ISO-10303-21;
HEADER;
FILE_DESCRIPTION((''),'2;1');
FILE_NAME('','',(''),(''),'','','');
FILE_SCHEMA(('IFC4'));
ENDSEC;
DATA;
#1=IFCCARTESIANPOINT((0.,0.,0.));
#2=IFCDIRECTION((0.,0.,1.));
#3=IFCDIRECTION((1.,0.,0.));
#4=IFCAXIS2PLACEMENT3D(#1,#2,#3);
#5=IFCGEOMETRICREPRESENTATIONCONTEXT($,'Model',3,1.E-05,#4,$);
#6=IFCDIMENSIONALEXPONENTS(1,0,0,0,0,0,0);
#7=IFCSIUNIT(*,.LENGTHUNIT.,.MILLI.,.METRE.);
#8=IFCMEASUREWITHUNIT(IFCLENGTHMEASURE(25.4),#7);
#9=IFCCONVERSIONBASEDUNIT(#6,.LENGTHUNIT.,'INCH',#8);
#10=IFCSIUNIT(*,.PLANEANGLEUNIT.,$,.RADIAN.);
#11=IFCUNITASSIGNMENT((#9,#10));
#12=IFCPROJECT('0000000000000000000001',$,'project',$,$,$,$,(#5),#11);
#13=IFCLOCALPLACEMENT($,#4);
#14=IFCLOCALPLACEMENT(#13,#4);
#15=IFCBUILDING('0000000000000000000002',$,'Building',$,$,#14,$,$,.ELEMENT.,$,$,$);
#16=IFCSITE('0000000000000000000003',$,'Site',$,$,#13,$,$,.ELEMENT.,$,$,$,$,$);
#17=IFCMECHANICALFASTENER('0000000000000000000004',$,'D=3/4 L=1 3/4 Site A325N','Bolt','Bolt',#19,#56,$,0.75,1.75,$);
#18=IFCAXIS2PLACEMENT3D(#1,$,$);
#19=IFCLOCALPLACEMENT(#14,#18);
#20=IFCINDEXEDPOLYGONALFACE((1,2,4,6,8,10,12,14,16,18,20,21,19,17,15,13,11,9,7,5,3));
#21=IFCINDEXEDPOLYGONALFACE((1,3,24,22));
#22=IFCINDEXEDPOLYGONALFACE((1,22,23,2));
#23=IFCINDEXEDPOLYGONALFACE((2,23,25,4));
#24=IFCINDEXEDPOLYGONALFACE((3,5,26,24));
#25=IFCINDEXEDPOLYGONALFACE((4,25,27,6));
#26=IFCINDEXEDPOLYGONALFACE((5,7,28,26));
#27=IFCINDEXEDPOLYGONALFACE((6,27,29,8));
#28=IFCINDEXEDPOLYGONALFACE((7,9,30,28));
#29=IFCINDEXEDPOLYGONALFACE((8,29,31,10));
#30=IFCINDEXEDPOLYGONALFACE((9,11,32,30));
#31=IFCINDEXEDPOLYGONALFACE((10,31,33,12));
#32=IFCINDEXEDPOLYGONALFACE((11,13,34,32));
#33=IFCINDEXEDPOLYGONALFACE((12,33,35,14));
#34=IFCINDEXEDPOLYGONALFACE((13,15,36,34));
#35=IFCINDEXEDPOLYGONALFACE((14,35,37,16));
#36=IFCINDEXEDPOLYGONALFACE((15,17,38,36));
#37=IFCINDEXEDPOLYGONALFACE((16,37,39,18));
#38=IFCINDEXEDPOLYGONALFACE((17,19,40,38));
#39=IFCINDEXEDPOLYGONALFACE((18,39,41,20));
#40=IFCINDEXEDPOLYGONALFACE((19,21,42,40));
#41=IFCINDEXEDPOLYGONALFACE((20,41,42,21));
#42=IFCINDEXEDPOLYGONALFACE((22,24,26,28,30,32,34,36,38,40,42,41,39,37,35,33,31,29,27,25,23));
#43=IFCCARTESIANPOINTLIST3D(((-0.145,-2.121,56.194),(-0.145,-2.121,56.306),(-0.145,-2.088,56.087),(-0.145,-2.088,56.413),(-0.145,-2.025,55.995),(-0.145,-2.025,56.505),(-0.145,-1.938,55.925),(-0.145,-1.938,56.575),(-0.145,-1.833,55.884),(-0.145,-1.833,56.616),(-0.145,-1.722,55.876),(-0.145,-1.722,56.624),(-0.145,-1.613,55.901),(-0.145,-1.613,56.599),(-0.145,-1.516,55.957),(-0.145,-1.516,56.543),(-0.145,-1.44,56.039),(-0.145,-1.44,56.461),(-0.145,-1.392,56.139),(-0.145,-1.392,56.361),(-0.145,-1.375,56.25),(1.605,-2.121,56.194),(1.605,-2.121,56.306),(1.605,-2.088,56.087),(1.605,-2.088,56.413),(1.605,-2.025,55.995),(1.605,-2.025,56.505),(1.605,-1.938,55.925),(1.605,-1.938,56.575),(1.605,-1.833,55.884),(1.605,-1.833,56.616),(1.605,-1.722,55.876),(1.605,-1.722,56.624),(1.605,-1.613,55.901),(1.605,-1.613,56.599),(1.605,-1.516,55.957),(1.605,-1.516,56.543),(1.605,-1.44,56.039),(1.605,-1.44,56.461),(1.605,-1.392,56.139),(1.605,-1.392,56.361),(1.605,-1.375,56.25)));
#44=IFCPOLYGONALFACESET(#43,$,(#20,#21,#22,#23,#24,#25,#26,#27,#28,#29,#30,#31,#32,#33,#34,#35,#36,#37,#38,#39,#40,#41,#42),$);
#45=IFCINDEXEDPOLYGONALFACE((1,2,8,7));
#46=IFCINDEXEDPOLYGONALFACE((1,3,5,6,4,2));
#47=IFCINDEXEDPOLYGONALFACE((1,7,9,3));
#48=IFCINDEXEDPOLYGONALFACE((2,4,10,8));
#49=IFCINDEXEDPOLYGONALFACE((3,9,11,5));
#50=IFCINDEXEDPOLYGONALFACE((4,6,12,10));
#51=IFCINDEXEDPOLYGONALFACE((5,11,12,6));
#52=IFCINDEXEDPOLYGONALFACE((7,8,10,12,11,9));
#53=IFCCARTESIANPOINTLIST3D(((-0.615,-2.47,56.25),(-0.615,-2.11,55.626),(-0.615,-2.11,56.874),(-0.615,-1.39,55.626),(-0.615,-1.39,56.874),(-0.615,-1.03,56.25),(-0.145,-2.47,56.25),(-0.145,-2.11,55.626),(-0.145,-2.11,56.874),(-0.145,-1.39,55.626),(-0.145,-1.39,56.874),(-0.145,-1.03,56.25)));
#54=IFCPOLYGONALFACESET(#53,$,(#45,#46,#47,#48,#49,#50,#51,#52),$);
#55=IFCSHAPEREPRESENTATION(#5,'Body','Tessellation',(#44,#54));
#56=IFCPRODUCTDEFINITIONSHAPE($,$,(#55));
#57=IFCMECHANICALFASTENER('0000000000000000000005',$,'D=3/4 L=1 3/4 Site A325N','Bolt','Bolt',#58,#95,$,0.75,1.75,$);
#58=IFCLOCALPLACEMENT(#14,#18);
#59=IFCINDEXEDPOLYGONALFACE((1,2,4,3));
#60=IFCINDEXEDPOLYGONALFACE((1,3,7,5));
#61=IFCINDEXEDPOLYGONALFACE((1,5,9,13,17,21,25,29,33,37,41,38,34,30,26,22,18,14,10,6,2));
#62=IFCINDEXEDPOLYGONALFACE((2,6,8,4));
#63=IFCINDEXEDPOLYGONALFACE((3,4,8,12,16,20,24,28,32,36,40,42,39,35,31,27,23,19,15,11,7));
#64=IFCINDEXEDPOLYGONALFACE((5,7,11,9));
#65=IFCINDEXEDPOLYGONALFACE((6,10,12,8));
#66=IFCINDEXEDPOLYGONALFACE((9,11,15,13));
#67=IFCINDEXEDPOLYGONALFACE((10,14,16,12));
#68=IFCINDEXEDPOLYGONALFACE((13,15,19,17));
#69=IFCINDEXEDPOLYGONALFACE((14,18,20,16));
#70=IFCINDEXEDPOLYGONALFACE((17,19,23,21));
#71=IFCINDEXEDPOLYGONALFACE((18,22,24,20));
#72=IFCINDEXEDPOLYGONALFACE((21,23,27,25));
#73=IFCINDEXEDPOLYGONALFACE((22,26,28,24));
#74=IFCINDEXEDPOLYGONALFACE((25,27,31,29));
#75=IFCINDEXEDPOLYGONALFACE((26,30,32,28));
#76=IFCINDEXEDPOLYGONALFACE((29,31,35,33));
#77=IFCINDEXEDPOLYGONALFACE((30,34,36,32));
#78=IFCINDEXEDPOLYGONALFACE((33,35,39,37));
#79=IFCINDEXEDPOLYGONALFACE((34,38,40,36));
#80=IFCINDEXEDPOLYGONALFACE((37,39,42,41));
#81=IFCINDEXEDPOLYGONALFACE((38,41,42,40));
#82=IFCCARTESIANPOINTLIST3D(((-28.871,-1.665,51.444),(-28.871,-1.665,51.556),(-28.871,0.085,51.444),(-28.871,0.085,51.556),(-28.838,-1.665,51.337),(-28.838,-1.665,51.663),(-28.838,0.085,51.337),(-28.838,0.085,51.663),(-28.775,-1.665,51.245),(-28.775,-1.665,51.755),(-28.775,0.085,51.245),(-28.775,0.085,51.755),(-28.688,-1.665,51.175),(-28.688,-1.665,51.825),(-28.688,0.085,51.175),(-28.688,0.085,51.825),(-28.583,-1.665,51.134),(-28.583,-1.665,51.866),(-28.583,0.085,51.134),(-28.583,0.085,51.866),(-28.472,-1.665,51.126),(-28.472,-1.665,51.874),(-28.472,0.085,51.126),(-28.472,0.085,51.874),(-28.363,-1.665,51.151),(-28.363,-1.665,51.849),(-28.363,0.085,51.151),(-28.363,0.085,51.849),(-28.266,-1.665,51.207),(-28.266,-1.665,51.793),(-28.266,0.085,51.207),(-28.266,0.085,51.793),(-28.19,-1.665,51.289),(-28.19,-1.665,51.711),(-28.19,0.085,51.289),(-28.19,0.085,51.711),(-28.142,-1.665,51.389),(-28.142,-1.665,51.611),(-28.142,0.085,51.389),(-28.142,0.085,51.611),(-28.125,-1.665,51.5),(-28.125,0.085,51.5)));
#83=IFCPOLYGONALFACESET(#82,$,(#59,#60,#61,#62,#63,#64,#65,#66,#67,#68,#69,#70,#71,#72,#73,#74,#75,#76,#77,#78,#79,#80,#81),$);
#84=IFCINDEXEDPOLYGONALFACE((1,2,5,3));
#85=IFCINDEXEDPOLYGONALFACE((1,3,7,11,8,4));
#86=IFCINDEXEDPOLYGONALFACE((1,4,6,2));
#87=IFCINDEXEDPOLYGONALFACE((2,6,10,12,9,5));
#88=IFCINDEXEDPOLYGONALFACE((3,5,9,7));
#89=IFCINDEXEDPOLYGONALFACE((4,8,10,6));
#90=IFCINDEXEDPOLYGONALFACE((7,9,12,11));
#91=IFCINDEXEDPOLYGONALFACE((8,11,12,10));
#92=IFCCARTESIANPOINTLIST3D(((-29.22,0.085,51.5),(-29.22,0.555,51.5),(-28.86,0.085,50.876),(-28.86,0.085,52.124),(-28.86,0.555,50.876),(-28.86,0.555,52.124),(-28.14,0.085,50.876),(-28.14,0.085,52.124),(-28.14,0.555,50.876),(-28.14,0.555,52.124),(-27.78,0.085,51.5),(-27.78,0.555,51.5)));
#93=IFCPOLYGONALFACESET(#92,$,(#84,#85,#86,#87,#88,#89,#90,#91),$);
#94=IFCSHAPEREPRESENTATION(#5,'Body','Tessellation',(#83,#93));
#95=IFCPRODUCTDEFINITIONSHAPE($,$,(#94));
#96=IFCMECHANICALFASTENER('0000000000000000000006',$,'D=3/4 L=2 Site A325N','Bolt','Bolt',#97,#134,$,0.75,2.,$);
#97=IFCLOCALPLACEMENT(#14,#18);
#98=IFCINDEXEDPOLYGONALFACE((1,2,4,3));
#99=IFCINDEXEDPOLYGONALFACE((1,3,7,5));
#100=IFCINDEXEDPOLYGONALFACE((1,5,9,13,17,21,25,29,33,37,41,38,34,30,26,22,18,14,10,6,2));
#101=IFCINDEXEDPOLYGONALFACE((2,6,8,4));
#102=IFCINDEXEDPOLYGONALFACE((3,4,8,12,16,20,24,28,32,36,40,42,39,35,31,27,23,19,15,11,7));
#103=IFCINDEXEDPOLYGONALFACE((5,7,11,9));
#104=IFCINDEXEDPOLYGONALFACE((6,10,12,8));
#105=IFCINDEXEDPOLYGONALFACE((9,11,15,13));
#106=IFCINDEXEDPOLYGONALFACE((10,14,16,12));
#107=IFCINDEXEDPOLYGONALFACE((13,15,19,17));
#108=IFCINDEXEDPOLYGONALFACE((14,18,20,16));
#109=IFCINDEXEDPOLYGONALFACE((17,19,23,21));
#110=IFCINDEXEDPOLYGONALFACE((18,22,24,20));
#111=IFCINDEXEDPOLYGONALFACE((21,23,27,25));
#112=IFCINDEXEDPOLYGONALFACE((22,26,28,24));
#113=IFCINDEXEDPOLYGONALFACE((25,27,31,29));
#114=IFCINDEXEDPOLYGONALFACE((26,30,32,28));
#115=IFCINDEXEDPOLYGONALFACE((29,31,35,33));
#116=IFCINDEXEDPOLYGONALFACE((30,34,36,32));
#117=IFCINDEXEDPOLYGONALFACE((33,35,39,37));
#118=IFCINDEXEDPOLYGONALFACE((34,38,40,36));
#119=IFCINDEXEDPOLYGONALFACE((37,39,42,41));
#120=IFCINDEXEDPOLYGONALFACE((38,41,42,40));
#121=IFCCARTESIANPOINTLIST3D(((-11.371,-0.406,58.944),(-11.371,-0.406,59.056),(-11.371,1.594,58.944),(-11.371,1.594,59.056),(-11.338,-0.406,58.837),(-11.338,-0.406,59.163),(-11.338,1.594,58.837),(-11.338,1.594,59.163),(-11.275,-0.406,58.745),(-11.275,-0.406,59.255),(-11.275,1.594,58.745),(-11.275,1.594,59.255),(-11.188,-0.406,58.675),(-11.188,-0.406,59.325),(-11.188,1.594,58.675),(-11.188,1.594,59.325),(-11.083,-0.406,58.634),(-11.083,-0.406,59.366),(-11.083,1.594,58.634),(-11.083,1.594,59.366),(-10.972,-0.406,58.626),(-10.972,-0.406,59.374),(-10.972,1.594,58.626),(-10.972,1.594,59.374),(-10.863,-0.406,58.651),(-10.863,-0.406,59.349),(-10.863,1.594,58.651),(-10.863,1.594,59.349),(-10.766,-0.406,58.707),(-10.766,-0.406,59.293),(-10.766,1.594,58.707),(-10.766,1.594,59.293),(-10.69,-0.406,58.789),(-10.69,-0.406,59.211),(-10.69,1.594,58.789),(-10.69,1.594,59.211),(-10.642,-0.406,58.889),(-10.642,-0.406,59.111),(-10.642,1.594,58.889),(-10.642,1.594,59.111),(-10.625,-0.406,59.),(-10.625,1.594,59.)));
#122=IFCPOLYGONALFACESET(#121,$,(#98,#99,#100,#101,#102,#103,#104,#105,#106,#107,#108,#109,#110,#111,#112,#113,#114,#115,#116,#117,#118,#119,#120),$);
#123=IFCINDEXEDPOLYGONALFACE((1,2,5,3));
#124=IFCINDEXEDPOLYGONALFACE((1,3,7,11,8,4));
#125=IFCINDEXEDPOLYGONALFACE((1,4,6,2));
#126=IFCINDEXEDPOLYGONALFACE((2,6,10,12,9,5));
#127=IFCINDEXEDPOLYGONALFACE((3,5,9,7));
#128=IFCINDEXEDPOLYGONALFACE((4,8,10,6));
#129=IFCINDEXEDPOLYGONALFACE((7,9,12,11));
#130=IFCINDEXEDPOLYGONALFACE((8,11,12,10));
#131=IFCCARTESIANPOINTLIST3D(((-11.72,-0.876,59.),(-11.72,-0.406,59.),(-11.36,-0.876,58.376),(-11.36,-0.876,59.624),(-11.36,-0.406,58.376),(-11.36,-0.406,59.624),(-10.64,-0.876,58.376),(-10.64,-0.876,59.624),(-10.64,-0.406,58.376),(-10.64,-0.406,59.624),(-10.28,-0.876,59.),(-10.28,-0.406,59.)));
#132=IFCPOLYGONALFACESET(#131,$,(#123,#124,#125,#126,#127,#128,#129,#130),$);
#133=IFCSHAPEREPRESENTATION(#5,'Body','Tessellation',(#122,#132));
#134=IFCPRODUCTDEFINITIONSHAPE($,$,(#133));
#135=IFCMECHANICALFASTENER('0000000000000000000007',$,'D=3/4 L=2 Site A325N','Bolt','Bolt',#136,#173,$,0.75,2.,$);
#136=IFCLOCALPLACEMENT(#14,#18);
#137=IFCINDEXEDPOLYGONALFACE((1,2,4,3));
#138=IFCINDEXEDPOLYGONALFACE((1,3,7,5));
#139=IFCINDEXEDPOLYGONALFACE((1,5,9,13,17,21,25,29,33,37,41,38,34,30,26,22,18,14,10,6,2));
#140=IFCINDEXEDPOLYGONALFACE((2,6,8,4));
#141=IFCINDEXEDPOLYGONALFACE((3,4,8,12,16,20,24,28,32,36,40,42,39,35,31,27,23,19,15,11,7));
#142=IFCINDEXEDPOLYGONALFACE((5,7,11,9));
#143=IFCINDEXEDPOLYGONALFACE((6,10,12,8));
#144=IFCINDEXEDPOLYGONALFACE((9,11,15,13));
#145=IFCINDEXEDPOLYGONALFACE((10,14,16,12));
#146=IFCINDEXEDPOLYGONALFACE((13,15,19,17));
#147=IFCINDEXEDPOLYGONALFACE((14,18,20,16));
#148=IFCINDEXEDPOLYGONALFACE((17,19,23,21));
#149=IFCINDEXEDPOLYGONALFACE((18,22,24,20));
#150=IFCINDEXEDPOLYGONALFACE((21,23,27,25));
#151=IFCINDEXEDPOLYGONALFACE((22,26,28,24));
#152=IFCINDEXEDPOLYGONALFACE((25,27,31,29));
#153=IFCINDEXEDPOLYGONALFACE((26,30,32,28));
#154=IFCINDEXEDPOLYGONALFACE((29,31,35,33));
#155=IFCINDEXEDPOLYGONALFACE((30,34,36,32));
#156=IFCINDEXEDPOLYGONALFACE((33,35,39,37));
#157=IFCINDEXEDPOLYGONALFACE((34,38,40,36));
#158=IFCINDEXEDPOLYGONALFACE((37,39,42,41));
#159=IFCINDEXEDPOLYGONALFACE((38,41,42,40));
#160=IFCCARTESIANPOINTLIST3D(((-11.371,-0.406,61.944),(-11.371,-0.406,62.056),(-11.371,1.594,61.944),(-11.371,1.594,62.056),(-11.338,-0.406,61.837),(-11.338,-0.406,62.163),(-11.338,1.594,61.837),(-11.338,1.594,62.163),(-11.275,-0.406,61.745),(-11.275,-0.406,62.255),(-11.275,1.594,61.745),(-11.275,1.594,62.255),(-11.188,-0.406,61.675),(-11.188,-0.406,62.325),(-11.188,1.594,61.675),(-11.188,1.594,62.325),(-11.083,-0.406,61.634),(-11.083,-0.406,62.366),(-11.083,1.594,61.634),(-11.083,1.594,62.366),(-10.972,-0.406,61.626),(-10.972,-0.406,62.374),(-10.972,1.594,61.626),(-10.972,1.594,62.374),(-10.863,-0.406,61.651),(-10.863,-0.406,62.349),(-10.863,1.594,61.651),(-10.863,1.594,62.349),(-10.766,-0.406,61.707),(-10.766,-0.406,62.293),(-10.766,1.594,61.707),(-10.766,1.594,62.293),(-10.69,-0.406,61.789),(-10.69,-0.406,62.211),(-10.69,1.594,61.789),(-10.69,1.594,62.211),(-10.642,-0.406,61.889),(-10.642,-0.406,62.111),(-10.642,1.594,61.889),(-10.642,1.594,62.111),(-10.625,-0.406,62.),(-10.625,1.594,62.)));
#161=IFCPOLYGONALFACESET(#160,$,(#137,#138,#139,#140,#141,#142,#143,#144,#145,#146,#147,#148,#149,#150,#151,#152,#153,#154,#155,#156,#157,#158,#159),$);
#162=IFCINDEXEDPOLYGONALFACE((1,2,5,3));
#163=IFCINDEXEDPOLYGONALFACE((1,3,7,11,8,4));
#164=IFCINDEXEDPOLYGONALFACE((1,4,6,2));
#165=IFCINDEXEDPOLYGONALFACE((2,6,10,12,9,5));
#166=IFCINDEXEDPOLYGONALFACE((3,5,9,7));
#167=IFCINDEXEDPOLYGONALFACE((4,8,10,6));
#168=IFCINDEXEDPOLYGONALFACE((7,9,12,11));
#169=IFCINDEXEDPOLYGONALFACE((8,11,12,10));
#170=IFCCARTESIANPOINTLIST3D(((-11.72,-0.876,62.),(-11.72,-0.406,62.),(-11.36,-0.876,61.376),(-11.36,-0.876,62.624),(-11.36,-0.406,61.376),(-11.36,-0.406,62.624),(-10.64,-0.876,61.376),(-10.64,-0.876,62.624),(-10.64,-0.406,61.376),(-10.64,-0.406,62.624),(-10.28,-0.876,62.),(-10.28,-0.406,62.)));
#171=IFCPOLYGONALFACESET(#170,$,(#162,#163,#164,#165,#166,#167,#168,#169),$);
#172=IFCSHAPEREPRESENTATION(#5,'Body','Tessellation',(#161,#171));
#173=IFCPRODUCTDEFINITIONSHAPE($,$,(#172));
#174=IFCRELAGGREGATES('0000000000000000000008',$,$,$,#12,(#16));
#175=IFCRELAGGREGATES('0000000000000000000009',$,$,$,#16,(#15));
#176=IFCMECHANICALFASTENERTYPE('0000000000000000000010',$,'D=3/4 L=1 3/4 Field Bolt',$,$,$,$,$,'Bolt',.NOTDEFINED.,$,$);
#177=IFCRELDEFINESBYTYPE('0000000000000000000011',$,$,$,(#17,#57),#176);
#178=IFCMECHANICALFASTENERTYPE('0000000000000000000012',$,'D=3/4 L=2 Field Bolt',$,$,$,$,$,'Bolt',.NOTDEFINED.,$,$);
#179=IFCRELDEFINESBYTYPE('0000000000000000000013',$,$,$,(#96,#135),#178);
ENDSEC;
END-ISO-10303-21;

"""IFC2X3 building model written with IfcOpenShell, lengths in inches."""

from ifc_helpers import new_model, entity, si_unit, converted_unit, frame, origin_with_axes, origin_2d_with_axis, place, context, project, spatial, polyline, circle, outline, extrude, source, transform, mapped, type_object, type_shapes, element, save


model = new_model("IFC2X3")

# Units and contexts
model_context = context("Model", 3, precision=1e-05, world=origin_with_axes())
ifc_project = project(units=[converted_unit("LENGTHUNIT", "INCH", entity("IfcLengthMeasure", 25.4), si_unit("LENGTHUNIT", "METRE", prefix="MILLI"), dimensions=[1, 0, 0, 0, 0, 0, 0]), si_unit("PLANEANGLEUNIT", "RADIAN")], contexts=[model_context])

# Site, building
site_placement = place(None, origin_with_axes())
site = spatial("IfcSite", under=ifc_project, at=site_placement, Name="Site", CompositionType="ELEMENT")
building_placement = place(site_placement, origin_with_axes())
building = spatial("IfcBuilding", under=site, at=building_placement, Name="Building", CompositionType="ELEMENT")

# Shared definitions
assembly_1_placement = place(building_placement, frame((-9.25, 0.0, 50.0), z_axis=(-1.0, 0.0, 0.0), x_axis=(0.0, 0.0, 1.0)))

# Shared definitions
assembly_2_placement = place(building_placement, frame((-9.25, 0.0, 57.0), z_axis=(0.0, 0.0, 1.0), x_axis=(-1.0, 0.0, 0.0)))

# Mechanical fasteners
mechanical_fastener_type_1 = type_object("IfcMechanicalFastenerType", Name="D=3/4 L=1 3/4 Field Bolt", ElementType="Bolt")
shared_shape_1 = source(origin_with_axes(), model_context, "Body", "SweptSolid", [
    extrude(circle(Radius=0.375, at=origin_2d_with_axis()), frame((0.0, 0.0, 0.0), z_axis=(1.0, 0.0, 0.0), x_axis=(0.0, 1.0, 0.0)), (0.0, 0.0, 1.0), 1.75),
    extrude(outline(polyline([(-0.72, 0.0), (-0.36, 0.624), (0.36, 0.624), (0.72, 0.0), (0.36, -0.624), (-0.36, -0.624), (-0.72, 0.0)])), frame((0.0, 0.0, 0.0), z_axis=(1.0, 0.0, 0.0), x_axis=(0.0, 1.0, 0.0)), (0.0, 0.0, -1.0), 0.47),
])
type_shapes(mechanical_fastener_type_1, [shared_shape_1])
placement_1 = place(building_placement, frame((0.0, 0.0, 54.5), z_axis=(0.0, -1.0, 0.0), x_axis=(0.0, 0.0, 1.0)))
placement_2 = place(placement_1, frame((1.75, 0.145, 1.75), z_axis=(1.0, 0.0, 0.0), x_axis=(0.0, -1.0, 0.0)))
mechanical_fastener_1_placement = place(placement_2, origin_with_axes())
element("IfcMechanicalFastener", 1, at=mechanical_fastener_1_placement, type_object=mechanical_fastener_type_1, Name="D=3/4 L=1 3/4 Site A325N", Description="Bolt", ObjectType="Bolt", NominalDiameter=0.75, NominalLength=1.75, context=model_context, shape_type="MappedRepresentation", body=[
    mapped(shared_shape_1, transform((0.0, 0.0, 0.0), scale=1.0)),
])
placement_3 = place(assembly_2_placement, frame((19.25, -0.085, -2.5), z_axis=(0.0, 0.0, 1.0), x_axis=(0.0, 1.0, 0.0)))
mechanical_fastener_2_placement = place(placement_3, frame((0.0, 0.0, -3.0), z_axis=(0.0, 0.0, 1.0), x_axis=(1.0, 0.0, 0.0)))
element("IfcMechanicalFastener", 2, at=mechanical_fastener_2_placement, type_object=mechanical_fastener_type_1, Name="D=3/4 L=1 3/4 Site A325N", Description="Bolt", ObjectType="Bolt", NominalDiameter=0.75, NominalLength=1.75, context=model_context, shape_type="MappedRepresentation", body=[
    mapped(shared_shape_1, transform((0.0, 0.0, 0.0), scale=1.0)),
])
mechanical_fastener_type_2 = type_object("IfcMechanicalFastenerType", Name="D=3/4 L=2 Field Bolt", ElementType="Bolt")
shared_shape_2 = source(origin_with_axes(), model_context, "Body", "SweptSolid", [
    extrude(circle(Radius=0.375, at=origin_2d_with_axis()), frame((0.0, 0.0, 0.0), z_axis=(1.0, 0.0, 0.0), x_axis=(0.0, 1.0, 0.0)), (0.0, 0.0, 1.0), 2.0),
    extrude(outline(polyline([(-0.72, 0.0), (-0.36, 0.624), (0.36, 0.624), (0.72, 0.0), (0.36, -0.624), (-0.36, -0.624), (-0.72, 0.0)])), frame((0.0, 0.0, 0.0), z_axis=(1.0, 0.0, 0.0), x_axis=(0.0, 1.0, 0.0)), (0.0, 0.0, -1.0), 0.47),
])
type_shapes(mechanical_fastener_type_2, [shared_shape_2])
placement_4 = place(assembly_1_placement, frame((9.0, -0.406, 1.75), z_axis=(-1.0, 0.0, 0.0), x_axis=(0.0, 1.0, 0.0)))
for number, where, z_axis, x_axis, name in (
    (3, (0.0, 0.0, 0.0), (0.0, 0.0, 1.0), (1.0, 0.0, 0.0), "D=3/4 L=2 Site A325N"),
    (4, (0.0, 0.0, -3.0), (0.0, 0.0, 1.0), (1.0, 0.0, 0.0), "D=3/4 L=2 Site A325N"),
):
    element("IfcMechanicalFastener", number, at=place(placement_4, frame(where, z_axis=z_axis, x_axis=x_axis)), type_object=mechanical_fastener_type_2, Name=name, Description="Bolt", ObjectType="Bolt", NominalDiameter=0.75, NominalLength=2.0, context=model_context, shape_type="MappedRepresentation", body=[
        mapped(shared_shape_2, transform((0.0, 0.0, 0.0), scale=1.0)),
    ])

save(model, "model.ifc")
